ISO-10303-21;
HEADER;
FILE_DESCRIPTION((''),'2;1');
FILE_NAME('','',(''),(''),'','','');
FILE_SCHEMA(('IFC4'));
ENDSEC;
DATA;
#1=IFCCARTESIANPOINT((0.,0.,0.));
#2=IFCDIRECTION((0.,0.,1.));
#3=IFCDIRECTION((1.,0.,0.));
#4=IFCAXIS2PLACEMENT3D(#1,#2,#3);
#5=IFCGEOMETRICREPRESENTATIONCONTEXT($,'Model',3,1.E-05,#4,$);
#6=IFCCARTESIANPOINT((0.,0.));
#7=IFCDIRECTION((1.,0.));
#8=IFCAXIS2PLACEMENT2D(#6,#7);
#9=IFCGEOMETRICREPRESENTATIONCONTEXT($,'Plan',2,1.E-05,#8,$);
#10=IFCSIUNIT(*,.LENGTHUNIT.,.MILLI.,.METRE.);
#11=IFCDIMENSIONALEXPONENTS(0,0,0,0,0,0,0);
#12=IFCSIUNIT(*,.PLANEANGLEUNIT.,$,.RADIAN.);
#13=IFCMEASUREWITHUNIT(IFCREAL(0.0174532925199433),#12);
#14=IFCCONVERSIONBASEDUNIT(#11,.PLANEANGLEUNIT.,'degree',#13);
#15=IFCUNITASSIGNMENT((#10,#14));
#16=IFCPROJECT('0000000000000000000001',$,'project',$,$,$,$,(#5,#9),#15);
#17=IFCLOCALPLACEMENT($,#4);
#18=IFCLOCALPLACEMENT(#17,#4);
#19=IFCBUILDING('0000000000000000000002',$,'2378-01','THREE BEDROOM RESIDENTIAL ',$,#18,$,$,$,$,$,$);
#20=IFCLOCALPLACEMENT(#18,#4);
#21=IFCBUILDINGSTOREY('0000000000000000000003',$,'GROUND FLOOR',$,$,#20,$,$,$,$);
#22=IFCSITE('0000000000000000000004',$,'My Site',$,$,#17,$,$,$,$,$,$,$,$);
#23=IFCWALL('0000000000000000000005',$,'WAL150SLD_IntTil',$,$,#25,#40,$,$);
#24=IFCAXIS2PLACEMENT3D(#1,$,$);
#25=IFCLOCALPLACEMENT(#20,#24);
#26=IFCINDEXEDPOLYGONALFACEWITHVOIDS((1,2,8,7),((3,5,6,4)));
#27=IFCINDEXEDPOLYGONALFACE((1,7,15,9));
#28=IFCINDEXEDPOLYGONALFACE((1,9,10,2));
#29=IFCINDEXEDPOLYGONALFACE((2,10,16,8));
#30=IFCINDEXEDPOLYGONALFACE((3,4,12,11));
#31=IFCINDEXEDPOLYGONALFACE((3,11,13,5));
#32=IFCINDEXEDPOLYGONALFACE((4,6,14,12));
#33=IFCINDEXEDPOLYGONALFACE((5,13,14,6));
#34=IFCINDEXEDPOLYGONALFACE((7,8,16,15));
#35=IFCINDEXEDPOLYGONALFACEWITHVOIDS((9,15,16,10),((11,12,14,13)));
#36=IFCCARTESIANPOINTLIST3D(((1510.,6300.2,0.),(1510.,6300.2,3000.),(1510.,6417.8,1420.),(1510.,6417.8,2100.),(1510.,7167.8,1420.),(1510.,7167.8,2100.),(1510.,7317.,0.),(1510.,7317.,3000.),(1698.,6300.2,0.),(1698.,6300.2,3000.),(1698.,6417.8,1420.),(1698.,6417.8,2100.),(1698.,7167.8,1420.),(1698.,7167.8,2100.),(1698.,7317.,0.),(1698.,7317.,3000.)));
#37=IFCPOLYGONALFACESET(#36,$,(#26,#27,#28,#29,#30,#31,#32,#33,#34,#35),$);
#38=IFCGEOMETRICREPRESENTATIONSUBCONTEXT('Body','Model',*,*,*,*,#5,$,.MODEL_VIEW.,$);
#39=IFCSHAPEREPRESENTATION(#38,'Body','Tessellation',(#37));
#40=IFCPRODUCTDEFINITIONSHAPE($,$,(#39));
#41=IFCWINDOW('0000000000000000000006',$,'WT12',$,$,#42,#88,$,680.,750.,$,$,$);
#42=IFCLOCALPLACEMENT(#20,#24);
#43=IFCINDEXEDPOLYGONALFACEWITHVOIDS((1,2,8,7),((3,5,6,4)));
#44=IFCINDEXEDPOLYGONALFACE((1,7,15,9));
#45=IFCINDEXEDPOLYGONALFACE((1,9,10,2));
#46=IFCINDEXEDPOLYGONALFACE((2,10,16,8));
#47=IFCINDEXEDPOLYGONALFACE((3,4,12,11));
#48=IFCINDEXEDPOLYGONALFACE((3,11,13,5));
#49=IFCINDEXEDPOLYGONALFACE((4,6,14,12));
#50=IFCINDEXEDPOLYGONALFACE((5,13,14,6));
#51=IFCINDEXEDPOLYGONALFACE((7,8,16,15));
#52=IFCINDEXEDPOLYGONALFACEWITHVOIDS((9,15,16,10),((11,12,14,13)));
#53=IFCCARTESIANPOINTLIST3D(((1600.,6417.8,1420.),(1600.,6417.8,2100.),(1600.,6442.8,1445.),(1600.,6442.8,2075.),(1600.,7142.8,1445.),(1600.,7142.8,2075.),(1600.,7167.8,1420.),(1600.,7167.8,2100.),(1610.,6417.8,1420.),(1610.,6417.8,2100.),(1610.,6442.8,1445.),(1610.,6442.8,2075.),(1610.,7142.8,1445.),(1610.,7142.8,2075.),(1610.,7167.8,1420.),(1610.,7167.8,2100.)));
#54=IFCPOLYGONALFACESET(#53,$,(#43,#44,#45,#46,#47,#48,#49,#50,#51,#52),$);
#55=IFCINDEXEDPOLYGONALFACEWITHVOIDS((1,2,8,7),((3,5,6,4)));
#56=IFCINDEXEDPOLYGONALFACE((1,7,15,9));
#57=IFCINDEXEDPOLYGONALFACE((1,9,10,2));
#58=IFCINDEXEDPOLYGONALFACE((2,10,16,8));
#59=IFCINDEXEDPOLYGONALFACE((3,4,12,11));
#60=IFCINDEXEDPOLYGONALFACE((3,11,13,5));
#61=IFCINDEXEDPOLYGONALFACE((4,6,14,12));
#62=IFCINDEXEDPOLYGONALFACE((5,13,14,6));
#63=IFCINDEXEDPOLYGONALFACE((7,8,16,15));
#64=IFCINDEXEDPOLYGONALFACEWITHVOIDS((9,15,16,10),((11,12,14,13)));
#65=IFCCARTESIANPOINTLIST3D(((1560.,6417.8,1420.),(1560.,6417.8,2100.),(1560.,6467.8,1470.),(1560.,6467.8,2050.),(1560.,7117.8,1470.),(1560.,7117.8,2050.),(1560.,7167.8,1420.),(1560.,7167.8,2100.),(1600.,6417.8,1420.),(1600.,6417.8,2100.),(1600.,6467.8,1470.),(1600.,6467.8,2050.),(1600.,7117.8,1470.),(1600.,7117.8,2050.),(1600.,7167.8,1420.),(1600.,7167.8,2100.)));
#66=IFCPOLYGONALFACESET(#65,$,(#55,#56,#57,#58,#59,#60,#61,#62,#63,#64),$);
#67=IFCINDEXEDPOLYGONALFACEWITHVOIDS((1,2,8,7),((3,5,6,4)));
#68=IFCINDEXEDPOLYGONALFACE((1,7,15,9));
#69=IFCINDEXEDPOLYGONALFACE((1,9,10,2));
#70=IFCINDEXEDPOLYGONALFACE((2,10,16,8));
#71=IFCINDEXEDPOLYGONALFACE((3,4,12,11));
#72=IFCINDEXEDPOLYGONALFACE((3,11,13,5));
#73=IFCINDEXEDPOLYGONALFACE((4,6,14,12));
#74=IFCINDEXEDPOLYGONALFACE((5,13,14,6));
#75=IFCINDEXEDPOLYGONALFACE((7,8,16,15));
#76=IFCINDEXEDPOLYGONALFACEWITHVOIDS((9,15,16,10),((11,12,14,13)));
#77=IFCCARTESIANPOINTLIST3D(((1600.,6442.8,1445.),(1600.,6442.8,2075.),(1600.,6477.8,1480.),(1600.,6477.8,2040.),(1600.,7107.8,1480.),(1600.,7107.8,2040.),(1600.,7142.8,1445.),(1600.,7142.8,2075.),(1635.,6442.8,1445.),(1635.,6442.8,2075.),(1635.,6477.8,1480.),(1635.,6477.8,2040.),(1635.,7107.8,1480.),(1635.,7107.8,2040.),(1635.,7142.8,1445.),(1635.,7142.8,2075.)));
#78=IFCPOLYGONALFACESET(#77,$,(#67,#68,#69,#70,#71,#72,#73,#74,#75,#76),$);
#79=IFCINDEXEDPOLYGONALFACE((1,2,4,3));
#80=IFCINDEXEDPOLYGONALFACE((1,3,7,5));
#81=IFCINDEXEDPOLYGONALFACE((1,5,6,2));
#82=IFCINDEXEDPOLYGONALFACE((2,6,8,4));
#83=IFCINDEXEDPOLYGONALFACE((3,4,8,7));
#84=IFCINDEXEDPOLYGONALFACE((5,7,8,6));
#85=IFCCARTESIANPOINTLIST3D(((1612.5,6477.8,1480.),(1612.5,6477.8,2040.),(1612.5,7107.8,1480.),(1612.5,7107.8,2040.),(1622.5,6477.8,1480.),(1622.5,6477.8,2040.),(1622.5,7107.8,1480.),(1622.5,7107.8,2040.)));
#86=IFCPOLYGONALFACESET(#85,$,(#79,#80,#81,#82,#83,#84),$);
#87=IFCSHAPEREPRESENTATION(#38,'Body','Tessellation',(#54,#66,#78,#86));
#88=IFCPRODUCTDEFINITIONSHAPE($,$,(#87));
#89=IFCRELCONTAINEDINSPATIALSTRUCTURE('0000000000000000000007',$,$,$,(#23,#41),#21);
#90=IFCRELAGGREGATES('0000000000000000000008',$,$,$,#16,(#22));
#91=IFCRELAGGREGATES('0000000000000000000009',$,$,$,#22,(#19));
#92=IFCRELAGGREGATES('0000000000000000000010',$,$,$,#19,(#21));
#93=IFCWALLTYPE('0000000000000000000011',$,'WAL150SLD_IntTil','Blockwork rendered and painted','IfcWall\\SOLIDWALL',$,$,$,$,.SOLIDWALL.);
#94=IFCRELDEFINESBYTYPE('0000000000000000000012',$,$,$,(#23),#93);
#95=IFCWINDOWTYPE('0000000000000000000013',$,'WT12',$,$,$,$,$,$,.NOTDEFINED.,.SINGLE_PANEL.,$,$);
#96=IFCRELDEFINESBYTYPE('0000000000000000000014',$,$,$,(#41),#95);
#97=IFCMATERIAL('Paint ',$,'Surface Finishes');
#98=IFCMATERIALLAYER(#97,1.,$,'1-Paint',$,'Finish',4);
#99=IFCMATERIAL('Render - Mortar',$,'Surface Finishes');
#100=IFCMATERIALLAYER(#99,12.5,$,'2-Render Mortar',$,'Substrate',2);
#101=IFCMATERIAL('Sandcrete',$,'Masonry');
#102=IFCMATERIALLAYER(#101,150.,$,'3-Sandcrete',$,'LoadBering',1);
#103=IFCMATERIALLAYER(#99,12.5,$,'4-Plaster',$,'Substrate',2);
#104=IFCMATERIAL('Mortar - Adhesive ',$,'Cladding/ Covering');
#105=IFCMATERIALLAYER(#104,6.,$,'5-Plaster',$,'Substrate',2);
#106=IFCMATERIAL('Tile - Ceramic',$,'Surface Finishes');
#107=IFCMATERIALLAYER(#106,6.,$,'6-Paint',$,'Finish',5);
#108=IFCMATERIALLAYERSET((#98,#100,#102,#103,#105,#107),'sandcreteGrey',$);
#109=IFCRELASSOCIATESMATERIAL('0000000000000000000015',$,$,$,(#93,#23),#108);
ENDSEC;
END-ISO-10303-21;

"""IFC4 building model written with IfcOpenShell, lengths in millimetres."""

from ifc_helpers import new_model, entity, si_unit, converted_unit, frame, origin_with_axes, origin_2d_with_axis, place, context, subcontext, project, spatial, line, indexed_curve, outline, extrude, shape, source, transform, mapped, material, layer, layer_set, layer_usage, type_object, type_shapes, element, fill, save


model = new_model("IFC4")

# Units and contexts
model_context = context("Model", 3, precision=1e-05, world=origin_with_axes())
plan_context = context("Plan", 2, precision=1e-05, world=origin_2d_with_axis())
body_context_1 = subcontext(model_context, "Body", "Model", "MODEL_VIEW")
body_context_2 = subcontext(plan_context, "Body", "Plan", "PLAN_VIEW")
ifc_project = project(units=[si_unit("LENGTHUNIT", "METRE", prefix="MILLI"), converted_unit("PLANEANGLEUNIT", "degree", entity("IfcReal", 0.0174532925199433), si_unit("PLANEANGLEUNIT", "RADIAN"), dimensions=[0, 0, 0, 0, 0, 0, 0])], contexts=[model_context, plan_context])

# Site, building, storey
site_placement = place(None, origin_with_axes())
site = spatial("IfcSite", under=ifc_project, at=site_placement, Name="My Site")
building_placement = place(site_placement, origin_with_axes())
building = spatial("IfcBuilding", under=site, at=building_placement, Name="2378-01", Description="THREE BEDROOM RESIDENTIAL ")
storey_placement = place(building_placement, origin_with_axes())
storey = spatial("IfcBuildingStorey", under=building, at=storey_placement, Name="GROUND FLOOR")

# Shared definitions
ifc_material_1 = material(Name="Paint ", Category="Surface Finishes")
ifc_material_2 = material(Name="Render - Mortar", Category="Surface Finishes")
ifc_material_3 = material(Name="Sandcrete", Category="Masonry")
ifc_material_4 = material(Name="Mortar - Adhesive ", Category="Cladding/ Covering")
ifc_material_5 = material(Name="Tile - Ceramic", Category="Surface Finishes")

# Wall, opening, window
ifc_layer_1 = layer(ifc_material_1, 1.0, Name="1-Paint", Category="Finish", Priority=4)
ifc_layer_2 = layer(ifc_material_2, 12.5, Name="2-Render Mortar", Category="Substrate", Priority=2)
ifc_layer_3 = layer(ifc_material_3, 150.0, Name="3-Sandcrete", Category="LoadBering", Priority=1)
ifc_layer_4 = layer(ifc_material_2, 12.5, Name="4-Plaster", Category="Substrate", Priority=2)
ifc_layer_5 = layer(ifc_material_4, 6.0, Name="5-Plaster", Category="Substrate", Priority=2)
ifc_layer_6 = layer(ifc_material_5, 6.0, Name="6-Paint", Category="Finish", Priority=5)
ifc_layer_set_1 = layer_set([ifc_layer_1, ifc_layer_2, ifc_layer_3, ifc_layer_4, ifc_layer_5, ifc_layer_6], Name="sandcreteGrey")
ifc_layer_usage_1 = layer_usage(ifc_layer_set_1, "AXIS2", "POSITIVE", 0.0)
wall_type_1 = type_object("IfcWallType", Name="WAL150SLD_IntTil", Description="Blockwork rendered and painted", ApplicableOccurrence="IfcWall\\SOLIDWALL", PredefinedType="SOLIDWALL", material=ifc_layer_set_1)
wall_1_placement = place(storey_placement, frame((1510.0, 7317.0, 0.0), z_axis=(0.0, 0.0, 1.0), x_axis=(-0.000001, -1.0, 0.0)))
wall_1 = element("IfcWall", 1, at=wall_1_placement, inside=storey, type_object=wall_type_1, material=ifc_layer_usage_1, Name="WAL150SLD_IntTil", context=body_context_1, shape_type="SweptSolid", body=[
    extrude(outline(indexed_curve([(0.0, 0.0), (0.0, 188.0), (1016.8, 188.0), (1016.8, 0.0), (0.0, 0.0)], self_intersect=False)), origin_with_axes(), (0.0, 0.0, 1.0), 3000.0),
])
shared_shape_1 = source(origin_with_axes(), body_context_1, "Body", "SweptSolid", [
    extrude(outline(indexed_curve([(0.0, 0.0), (750.0, 0.0), (750.0, 680.0), (0.0, 680.0)], segments=[line(1, 2, 3, 4, 1)])), frame((0.0, -600.0, 0.0), z_axis=(0.0, -1.0, 0.0), x_axis=(1.0, 0.0, 0.0)), (0.0, 0.0, -1.0), 1200.0),
])
opening_1_placement = place(wall_1_placement, frame((149.2, 0.0, 1420.0), z_axis=(0.0, 0.0, 1.0), x_axis=(1.0, 0.0, 0.0)))
opening_1 = element("IfcOpeningElement", 2, at=opening_1_placement, cuts=wall_1, PredefinedType="OPENING", context=body_context_1, shape_type="MappedRepresentation", body=[
    mapped(shared_shape_1, transform((0.0, 0.0, 0.0), x_axis=(1.0, 0.0, 0.0), y_axis=(0.0, 1.0, 0.0), z_axis=(0.0, 0.0, 1.0), scale=1.0)),
])
window_type_1 = type_object("IfcWindowType", Name="WT12", PartitioningType="SINGLE_PANEL", PredefinedType="NOTDEFINED")
shared_shape_2 = source(origin_with_axes(), body_context_1, "Body", "SweptSolid", [
    extrude(outline(indexed_curve([(0.0, 0.0), (750.0, 0.0), (750.0, 680.0), (0.0, 680.0)], segments=[line(1, 2, 3, 4, 1)]), holes=[indexed_curve([(25.0, 25.0), (725.0, 25.0), (725.0, 655.0), (25.0, 655.0)], segments=[line(1, 2, 3, 4, 1)])]), frame((0.0, 90.0, 0.0), z_axis=(0.0, -1.0, 0.0), x_axis=(1.0, 0.0, 0.0)), (0.0, 0.0, -1.0), 10.0),
    extrude(outline(indexed_curve([(0.0, 0.0), (750.0, 0.0), (750.0, 680.0), (0.0, 680.0)], segments=[line(1, 2, 3, 4, 1)]), holes=[indexed_curve([(50.0, 50.0), (700.0, 50.0), (700.0, 630.0), (50.0, 630.0)], segments=[line(1, 2, 3, 4, 1)])]), frame((0.0, 50.0, 0.0), z_axis=(0.0, -1.0, 0.0), x_axis=(1.0, 0.0, 0.0)), (0.0, 0.0, -1.0), 40.0),
    extrude(outline(indexed_curve([(0.0, 0.0), (700.0, 0.0), (700.0, 630.0), (0.0, 630.0)], segments=[line(1, 2, 3, 4, 1)]), holes=[indexed_curve([(35.0, 35.0), (665.0, 35.0), (665.0, 595.0), (35.0, 595.0)], segments=[line(1, 2, 3, 4, 1)])]), frame((25.0, 90.0, 25.0), z_axis=(0.0, -1.0, 0.0), x_axis=(1.0, 0.0, 0.0)), (0.0, 0.0, -1.0), 35.0),
    extrude(outline(indexed_curve([(35.0, 35.0), (665.0, 35.0), (665.0, 595.0), (35.0, 595.0)], segments=[line(1, 2, 3, 4, 1)])), frame((25.0, 102.5, 25.0), z_axis=(0.0, -1.0, 0.0), x_axis=(1.0, 0.0, 0.0)), (0.0, 0.0, -1.0), 10.0),
])
shared_shape_3 = source(origin_with_axes(), body_context_2, "Body", "Curve2D", [
    entity("IfcIndexedPolyCurve", entity("IfcCartesianPointList2D", [[50.0, 50.0], [700.0, 50.0]])),
    entity("IfcIndexedPolyCurve", entity("IfcCartesianPointList2D", [[0.0, 100.0], [25.0, 100.0], [25.0, 90.0], [50.0, 90.0], [50.0, 50.0], [0.0, 50.0]]), [entity("IfcLineIndex", [1, 2, 3, 4, 5, 6, 1])]),
    entity("IfcIndexedPolyCurve", entity("IfcCartesianPointList2D", [[750.0, 100.0], [725.0, 100.0], [725.0, 90.0], [700.0, 90.0], [700.0, 50.0], [750.0, 50.0]]), [entity("IfcLineIndex", [1, 2, 3, 4, 5, 6, 1])]),
    entity("IfcIndexedPolyCurve", entity("IfcCartesianPointList2D", [[25.0, 90.0], [60.0, 90.0], [60.0, 125.0], [25.0, 125.0]]), [entity("IfcLineIndex", [1, 2, 3, 4, 1])]),
    entity("IfcIndexedPolyCurve", entity("IfcCartesianPointList2D", [[725.0, 90.0], [690.0, 90.0], [690.0, 125.0], [725.0, 125.0]]), [entity("IfcLineIndex", [1, 2, 3, 4, 1])]),
    entity("IfcIndexedPolyCurve", entity("IfcCartesianPointList2D", [[60.0, 90.0], [690.0, 90.0]])),
    entity("IfcIndexedPolyCurve", entity("IfcCartesianPointList2D", [[60.0, 125.0], [690.0, 125.0]])),
    entity("IfcIndexedPolyCurve", entity("IfcCartesianPointList2D", [[60.0, 107.5], [690.0, 107.5]])),
])
type_shapes(window_type_1, [shared_shape_2, shared_shape_3])
window_1_placement = place(opening_1_placement, frame((0.0, 0.0, 0.0), z_axis=(0.0, 0.0, 1.0), x_axis=(1.0, 0.0, 0.0)))
window_1 = element("IfcWindow", 3, at=window_1_placement, inside=storey, type_object=window_type_1, Name="WT12", OverallHeight=680.0, OverallWidth=750.0, shapes=[
    shape(body_context_1, "Body", "MappedRepresentation", [mapped(shared_shape_2, transform((0.0, 0.0, 0.0), x_axis=(1.0, 0.0, 0.0), y_axis=(0.0, 1.0, 0.0), z_axis=(0.0, 0.0, 1.0), scale=1.0))]),
    shape(body_context_2, "Body", "MappedRepresentation", [mapped(shared_shape_3, transform((0.0, 0.0, 0.0), x_axis=(1.0, 0.0, 0.0), y_axis=(0.0, 1.0, 0.0), z_axis=(0.0, 0.0, 1.0), scale=1.0))]),
])
fill(opening_1, window_1)

save(model, "model.ifc")
